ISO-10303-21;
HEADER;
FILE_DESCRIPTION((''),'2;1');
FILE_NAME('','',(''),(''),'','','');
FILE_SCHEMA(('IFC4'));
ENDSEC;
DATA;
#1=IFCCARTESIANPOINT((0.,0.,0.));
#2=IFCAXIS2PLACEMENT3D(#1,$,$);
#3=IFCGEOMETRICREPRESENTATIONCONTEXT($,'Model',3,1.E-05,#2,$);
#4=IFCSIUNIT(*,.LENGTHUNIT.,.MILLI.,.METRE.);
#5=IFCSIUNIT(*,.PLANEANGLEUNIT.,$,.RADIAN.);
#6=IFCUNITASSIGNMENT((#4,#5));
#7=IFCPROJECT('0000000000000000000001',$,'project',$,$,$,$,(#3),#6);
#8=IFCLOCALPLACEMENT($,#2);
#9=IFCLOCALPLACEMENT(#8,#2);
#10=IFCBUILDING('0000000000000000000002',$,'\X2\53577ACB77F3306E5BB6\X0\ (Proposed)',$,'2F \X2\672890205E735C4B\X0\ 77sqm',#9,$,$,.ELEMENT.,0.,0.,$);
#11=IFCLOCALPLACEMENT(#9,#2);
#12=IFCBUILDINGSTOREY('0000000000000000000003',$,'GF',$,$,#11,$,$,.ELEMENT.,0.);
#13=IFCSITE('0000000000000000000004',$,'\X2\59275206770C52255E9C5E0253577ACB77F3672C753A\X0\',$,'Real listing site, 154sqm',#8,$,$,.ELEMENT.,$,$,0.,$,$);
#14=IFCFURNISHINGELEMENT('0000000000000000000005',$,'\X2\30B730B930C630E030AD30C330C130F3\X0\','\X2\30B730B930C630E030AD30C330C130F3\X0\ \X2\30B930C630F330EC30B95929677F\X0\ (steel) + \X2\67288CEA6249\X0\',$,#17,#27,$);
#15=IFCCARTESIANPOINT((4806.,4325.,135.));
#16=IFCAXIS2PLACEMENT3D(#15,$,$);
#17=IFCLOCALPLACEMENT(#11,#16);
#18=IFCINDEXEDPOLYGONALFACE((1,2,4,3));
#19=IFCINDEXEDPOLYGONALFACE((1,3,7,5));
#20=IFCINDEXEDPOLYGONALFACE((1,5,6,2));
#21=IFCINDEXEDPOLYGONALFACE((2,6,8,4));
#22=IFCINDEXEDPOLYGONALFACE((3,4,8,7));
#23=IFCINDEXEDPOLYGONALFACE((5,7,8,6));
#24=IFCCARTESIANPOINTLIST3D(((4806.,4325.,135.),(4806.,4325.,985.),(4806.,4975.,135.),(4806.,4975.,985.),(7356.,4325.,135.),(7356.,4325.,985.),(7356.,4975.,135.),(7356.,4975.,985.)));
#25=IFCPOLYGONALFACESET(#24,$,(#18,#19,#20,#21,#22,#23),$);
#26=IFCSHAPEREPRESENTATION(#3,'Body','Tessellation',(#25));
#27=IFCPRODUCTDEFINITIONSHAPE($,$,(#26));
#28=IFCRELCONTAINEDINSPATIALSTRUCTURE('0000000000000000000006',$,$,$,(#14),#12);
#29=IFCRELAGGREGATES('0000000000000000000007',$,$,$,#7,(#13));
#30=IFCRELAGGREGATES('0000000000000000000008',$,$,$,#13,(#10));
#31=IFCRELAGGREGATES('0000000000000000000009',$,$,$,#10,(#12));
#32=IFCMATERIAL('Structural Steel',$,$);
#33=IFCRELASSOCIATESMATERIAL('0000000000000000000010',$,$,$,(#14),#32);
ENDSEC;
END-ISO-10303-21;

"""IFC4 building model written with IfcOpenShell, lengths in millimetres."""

from ifc_helpers import new_model, si_unit, frame, frame_2d, origin, place, context, project, spatial, rectangle, extrude, material, element, save


model = new_model("IFC4")

# Units and contexts
model_context = context("Model", 3, precision=1e-05, world=origin())
ifc_project = project(units=[si_unit("LENGTHUNIT", "METRE", prefix="MILLI"), si_unit("PLANEANGLEUNIT", "RADIAN")], contexts=[model_context])

# Site, building, storey
site_placement = place(None, origin())
site = spatial("IfcSite", under=ifc_project, at=site_placement, Name="大分県別府市南立石本町", ObjectType="Real listing site, 154sqm", CompositionType="ELEMENT", RefElevation=0.0)
building_placement = place(site_placement, origin())
building = spatial("IfcBuilding", under=site, at=building_placement, Name="南立石の家 (Proposed)", ObjectType="2F 木造平屋 77sqm", CompositionType="ELEMENT", ElevationOfRefHeight=0.0, ElevationOfTerrain=0.0)
storey_placement = place(building_placement, origin())
storey = spatial("IfcBuildingStorey", under=building, at=storey_placement, Name="GF", CompositionType="ELEMENT", Elevation=0.0)

# Furnishing element
ifc_material_1 = material(Name="Structural Steel")
furnishing_1_placement = place(storey_placement, frame((4806.0, 4325.0, 135.0)))
element("IfcFurnishingElement", 1, at=furnishing_1_placement, inside=storey, material=ifc_material_1, Name="システムキッチン", Description="システムキッチン ステンレス天板 (steel) + 木質扉", context=model_context, shape_type="SweptSolid", body=[
    extrude(rectangle(XDim=2550.0, YDim=650.0, at=frame_2d((1275.0, 325.0))), frame((4806.0, 4325.0, 135.0)), (0.0, 0.0, 1.0), 850.0),
])

save(model, "model.ifc")
